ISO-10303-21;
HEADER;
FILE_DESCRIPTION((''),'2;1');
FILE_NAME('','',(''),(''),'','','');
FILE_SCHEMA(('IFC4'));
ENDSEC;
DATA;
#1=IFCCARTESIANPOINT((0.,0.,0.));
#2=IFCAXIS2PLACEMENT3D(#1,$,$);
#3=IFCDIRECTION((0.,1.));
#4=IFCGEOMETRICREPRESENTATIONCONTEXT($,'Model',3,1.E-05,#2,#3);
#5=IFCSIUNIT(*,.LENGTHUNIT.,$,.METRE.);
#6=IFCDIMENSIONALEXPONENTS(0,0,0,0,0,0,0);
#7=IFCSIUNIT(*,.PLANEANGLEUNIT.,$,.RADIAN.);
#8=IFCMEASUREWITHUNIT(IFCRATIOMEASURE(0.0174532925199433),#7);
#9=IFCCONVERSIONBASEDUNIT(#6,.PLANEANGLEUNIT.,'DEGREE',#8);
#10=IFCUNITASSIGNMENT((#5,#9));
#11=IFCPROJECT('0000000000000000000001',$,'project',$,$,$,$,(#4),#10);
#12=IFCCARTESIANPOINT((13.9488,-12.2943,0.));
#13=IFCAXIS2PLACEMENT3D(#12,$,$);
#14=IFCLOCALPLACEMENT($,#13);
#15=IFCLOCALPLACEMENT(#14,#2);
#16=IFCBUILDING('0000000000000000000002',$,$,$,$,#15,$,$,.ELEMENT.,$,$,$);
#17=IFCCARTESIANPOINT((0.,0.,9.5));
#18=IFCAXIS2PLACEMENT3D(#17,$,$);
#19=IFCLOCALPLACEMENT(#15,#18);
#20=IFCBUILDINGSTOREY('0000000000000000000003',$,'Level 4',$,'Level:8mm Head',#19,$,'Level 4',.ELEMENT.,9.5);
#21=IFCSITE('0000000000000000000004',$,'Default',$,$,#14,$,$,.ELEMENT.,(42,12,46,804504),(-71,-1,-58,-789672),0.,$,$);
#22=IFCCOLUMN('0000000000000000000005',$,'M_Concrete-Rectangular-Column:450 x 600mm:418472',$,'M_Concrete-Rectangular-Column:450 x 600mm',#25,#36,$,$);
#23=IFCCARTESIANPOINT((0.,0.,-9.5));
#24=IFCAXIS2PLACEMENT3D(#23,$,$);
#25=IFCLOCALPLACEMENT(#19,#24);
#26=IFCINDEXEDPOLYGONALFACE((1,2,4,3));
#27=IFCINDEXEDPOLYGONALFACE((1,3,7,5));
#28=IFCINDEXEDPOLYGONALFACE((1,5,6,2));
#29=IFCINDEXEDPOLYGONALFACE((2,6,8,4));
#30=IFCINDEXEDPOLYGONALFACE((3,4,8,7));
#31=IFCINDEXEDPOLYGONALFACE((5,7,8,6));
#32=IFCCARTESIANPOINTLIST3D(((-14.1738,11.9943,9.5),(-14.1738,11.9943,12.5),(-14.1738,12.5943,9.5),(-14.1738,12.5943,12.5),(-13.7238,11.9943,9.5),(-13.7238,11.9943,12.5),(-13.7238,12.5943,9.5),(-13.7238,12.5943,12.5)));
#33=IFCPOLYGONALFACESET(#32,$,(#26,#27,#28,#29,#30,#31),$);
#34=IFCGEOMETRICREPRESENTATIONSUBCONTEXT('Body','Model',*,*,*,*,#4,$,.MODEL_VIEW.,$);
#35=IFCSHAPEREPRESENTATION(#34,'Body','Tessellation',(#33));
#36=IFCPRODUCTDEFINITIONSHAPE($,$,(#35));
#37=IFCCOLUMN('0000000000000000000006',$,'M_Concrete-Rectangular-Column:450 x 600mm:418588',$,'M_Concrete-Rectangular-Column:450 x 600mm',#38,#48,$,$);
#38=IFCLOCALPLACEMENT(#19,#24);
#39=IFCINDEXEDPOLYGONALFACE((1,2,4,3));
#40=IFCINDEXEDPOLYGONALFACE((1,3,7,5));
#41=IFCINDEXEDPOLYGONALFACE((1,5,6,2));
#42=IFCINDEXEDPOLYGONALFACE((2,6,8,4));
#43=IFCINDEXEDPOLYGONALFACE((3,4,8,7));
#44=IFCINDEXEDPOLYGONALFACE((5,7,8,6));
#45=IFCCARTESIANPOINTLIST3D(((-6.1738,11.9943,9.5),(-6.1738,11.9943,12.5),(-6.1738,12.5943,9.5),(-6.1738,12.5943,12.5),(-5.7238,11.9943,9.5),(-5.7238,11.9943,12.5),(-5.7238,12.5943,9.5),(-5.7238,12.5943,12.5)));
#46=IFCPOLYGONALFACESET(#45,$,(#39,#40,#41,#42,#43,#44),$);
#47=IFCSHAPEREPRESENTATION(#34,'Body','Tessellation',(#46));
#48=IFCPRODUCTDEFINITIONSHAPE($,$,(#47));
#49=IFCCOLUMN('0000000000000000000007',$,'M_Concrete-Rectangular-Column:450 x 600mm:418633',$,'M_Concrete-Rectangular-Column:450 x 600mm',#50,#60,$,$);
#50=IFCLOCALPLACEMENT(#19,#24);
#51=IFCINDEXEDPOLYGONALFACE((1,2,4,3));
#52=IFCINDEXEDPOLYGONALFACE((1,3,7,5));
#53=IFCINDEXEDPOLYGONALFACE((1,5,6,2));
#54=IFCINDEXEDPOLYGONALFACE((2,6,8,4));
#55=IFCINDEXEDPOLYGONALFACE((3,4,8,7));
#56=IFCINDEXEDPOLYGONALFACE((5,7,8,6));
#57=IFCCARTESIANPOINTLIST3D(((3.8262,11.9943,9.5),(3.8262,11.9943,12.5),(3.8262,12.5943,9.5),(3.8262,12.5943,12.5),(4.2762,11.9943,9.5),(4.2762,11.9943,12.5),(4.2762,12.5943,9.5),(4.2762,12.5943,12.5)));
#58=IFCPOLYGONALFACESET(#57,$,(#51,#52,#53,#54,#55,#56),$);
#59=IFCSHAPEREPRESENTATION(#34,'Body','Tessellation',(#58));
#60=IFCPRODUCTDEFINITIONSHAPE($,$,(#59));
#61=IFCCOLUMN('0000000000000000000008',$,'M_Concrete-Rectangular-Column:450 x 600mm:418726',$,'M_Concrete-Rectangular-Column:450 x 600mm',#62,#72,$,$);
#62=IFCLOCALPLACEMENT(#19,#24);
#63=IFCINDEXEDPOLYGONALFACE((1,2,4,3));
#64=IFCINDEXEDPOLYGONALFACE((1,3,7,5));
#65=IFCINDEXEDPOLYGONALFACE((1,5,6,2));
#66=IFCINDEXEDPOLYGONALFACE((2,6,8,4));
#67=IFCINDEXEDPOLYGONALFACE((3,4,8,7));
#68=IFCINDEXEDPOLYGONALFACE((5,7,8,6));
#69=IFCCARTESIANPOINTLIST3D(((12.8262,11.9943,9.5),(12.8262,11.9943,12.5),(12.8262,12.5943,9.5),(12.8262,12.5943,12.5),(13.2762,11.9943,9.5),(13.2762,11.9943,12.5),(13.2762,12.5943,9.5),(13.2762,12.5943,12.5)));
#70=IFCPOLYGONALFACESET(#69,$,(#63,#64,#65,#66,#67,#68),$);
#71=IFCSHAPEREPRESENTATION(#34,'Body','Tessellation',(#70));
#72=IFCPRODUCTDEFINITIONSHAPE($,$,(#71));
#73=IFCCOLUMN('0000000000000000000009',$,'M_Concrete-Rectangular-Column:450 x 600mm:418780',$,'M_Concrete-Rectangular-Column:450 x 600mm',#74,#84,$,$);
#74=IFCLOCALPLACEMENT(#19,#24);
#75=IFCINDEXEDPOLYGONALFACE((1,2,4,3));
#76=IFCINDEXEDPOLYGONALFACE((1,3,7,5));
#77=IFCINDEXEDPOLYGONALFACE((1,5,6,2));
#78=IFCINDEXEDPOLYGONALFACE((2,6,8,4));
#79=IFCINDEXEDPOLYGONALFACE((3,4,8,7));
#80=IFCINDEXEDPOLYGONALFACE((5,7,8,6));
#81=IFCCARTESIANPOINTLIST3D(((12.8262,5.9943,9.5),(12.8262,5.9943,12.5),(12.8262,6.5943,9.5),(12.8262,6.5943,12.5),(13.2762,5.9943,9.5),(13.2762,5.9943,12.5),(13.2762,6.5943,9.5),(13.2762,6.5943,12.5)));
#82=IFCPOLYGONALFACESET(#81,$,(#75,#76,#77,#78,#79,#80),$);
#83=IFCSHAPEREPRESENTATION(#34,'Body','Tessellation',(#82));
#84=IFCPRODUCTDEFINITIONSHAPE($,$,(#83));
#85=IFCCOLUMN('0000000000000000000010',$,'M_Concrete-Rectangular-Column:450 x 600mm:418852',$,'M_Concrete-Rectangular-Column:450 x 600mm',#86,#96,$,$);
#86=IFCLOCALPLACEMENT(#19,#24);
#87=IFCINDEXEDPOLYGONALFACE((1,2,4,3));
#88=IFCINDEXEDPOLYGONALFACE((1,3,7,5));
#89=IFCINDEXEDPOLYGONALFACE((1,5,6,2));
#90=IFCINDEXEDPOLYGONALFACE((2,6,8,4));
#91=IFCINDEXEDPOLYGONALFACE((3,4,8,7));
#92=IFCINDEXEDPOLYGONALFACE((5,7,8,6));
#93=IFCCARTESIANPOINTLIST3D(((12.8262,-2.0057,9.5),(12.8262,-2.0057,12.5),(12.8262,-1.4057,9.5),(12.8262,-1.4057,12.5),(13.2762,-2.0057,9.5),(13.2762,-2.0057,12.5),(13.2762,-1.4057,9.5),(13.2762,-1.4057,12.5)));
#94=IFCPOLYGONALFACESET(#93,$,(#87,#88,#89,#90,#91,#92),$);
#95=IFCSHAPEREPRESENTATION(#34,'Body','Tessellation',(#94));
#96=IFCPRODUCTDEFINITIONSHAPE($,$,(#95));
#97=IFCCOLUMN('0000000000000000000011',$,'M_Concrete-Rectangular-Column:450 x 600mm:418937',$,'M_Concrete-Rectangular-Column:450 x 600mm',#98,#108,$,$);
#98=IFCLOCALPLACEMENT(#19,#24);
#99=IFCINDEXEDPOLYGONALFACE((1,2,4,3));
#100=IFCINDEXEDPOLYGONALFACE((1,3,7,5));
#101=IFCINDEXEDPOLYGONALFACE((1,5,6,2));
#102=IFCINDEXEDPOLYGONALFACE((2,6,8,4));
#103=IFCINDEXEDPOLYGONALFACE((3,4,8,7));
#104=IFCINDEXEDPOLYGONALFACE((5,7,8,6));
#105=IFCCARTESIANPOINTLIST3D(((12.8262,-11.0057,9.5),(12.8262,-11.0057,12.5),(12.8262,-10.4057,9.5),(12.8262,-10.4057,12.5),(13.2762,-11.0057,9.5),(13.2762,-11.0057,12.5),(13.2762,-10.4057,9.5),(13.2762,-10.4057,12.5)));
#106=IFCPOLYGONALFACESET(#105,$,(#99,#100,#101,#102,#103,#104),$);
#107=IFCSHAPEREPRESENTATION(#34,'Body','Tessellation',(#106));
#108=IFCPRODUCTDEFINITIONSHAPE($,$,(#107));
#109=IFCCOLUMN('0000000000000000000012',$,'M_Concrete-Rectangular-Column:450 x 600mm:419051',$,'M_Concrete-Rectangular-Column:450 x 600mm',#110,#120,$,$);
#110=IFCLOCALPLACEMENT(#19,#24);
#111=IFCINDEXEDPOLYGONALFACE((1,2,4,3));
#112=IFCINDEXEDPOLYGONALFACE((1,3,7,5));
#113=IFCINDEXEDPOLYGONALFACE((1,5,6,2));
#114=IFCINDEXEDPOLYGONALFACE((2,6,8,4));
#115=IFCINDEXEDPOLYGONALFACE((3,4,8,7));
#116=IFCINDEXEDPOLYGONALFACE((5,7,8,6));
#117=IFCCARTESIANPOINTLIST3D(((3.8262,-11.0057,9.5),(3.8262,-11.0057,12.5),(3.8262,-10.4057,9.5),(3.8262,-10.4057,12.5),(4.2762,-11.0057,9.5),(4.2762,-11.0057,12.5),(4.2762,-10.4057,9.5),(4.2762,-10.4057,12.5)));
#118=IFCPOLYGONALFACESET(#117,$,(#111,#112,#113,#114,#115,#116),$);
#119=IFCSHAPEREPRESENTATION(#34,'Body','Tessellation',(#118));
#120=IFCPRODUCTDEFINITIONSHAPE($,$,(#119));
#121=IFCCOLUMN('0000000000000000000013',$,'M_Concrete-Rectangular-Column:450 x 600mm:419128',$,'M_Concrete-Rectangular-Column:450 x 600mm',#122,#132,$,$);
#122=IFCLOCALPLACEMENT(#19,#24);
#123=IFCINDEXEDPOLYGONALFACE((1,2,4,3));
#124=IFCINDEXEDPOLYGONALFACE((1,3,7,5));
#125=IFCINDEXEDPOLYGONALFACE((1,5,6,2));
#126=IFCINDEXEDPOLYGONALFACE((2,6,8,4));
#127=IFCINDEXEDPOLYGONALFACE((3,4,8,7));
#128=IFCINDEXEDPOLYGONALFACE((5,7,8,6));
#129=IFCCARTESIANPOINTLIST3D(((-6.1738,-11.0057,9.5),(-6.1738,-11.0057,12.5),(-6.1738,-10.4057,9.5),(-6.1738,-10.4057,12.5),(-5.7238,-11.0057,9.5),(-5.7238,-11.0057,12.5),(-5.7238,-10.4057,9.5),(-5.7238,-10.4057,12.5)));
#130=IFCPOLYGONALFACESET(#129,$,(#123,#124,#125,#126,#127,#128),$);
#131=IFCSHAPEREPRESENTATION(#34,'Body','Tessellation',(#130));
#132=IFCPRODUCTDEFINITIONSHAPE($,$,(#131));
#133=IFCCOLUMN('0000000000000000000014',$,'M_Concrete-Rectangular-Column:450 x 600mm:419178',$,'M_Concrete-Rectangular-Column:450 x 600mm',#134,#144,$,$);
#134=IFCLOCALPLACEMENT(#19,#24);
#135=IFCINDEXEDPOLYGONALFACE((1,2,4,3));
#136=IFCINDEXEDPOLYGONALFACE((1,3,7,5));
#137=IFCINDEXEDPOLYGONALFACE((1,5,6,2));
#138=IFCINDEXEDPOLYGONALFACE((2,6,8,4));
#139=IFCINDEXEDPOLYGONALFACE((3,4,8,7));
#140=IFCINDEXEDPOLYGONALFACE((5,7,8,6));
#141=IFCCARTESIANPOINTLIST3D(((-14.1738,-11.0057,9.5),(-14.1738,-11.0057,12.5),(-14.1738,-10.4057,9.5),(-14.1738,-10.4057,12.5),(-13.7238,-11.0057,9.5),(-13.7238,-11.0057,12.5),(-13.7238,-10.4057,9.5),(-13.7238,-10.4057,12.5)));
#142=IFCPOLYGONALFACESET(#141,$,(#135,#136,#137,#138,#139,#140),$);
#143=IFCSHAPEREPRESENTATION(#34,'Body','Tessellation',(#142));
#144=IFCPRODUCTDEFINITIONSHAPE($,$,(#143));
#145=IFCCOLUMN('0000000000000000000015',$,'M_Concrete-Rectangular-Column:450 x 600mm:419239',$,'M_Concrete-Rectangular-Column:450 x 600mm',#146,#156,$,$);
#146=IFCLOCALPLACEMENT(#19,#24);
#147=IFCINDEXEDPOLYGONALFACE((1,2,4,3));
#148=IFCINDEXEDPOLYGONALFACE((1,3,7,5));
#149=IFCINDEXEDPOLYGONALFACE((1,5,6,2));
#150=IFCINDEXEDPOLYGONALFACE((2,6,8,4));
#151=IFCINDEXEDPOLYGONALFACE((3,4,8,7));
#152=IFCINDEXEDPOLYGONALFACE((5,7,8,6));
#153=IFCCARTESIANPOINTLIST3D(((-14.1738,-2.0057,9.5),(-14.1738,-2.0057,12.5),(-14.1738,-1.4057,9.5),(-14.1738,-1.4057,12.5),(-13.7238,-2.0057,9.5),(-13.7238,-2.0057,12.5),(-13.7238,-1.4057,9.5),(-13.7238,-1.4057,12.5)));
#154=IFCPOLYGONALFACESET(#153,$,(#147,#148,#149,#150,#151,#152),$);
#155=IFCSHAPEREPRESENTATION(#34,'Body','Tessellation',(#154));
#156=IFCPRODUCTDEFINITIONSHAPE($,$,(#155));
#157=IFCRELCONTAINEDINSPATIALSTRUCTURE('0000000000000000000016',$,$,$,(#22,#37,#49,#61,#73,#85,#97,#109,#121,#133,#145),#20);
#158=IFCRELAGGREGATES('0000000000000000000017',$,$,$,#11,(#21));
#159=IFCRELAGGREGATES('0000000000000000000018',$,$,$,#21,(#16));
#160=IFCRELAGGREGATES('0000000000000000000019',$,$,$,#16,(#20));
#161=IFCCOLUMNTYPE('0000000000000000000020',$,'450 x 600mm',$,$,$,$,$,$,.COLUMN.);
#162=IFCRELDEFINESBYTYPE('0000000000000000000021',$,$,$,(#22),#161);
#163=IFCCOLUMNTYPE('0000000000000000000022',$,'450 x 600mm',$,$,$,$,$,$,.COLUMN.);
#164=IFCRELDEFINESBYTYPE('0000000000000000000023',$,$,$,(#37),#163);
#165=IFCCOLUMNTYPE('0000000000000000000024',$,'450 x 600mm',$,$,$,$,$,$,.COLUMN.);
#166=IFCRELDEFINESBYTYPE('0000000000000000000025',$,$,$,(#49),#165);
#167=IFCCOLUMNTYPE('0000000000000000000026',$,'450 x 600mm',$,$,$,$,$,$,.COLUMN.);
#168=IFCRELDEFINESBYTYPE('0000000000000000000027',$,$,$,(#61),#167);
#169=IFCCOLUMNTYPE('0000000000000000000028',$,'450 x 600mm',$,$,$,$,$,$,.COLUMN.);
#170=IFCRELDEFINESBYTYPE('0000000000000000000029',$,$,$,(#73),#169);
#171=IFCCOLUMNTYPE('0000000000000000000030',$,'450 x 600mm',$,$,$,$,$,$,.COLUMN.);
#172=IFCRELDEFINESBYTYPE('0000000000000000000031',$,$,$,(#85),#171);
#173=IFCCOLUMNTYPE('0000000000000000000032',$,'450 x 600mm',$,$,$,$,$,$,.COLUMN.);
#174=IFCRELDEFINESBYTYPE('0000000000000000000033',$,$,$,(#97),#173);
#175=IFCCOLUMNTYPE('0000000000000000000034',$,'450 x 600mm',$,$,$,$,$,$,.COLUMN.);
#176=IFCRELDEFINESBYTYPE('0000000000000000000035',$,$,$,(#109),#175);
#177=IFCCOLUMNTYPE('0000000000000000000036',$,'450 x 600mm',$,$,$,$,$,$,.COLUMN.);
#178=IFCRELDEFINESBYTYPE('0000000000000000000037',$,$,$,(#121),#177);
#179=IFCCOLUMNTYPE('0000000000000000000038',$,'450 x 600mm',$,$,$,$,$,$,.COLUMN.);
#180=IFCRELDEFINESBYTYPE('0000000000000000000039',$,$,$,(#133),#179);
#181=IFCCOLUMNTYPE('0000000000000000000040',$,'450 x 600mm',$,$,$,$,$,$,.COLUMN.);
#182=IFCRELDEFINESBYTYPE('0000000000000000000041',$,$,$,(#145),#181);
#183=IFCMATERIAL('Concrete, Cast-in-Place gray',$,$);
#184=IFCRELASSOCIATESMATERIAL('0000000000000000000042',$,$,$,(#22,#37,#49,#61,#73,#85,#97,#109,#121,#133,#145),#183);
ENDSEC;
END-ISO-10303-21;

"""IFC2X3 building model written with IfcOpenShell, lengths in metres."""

from ifc_helpers import new_model, entity, si_unit, converted_unit, direction, frame, frame_2d, origin, origin_2d_with_axis, place, context, subcontext, project, spatial, rectangle, extrude, source, transform, mapped, material, type_object, type_shapes, element, save


model = new_model("IFC2X3")

# Units and contexts
model_context = context("Model", 3, precision=1e-05, world=origin(), true_north=direction((0.0, 1.0)))
body_context = subcontext(model_context, "Body", "Model", "MODEL_VIEW")
ifc_project = project(units=[si_unit("LENGTHUNIT", "METRE"), converted_unit("PLANEANGLEUNIT", "DEGREE", entity("IfcRatioMeasure", 0.0174532925199433), si_unit("PLANEANGLEUNIT", "RADIAN"), dimensions=[0, 0, 0, 0, 0, 0, 0])], contexts=[model_context])

# Site, building, storey
site_placement = place(None, frame((13.9488, -12.2943, 0.0)))
site = spatial("IfcSite", under=ifc_project, at=site_placement, Name="Default", CompositionType="ELEMENT", RefLatitude=(42, 12, 46, 804504), RefLongitude=(-71, -1, -58, -789672), RefElevation=0.0)
building_placement = place(site_placement, origin())
building = spatial("IfcBuilding", under=site, at=building_placement, CompositionType="ELEMENT")
storey_placement = place(building_placement, frame((0.0, 0.0, 9.5)))
storey = spatial("IfcBuildingStorey", under=building, at=storey_placement, Name="Level 4", ObjectType="Level:8mm Head", LongName="Level 4", CompositionType="ELEMENT", Elevation=9.5)

# Columns
ifc_material = material(Name="Concrete, Cast-in-Place gray")
column_type_1 = type_object("IfcColumnType", Name="450 x 600mm", PredefinedType="COLUMN")
shared_shape_1 = source(origin(), body_context, "Body", "SweptSolid", [
    extrude(rectangle(XDim=0.6, YDim=0.45, at=frame_2d((0.0, 0.0), x_axis=(1.0, 0.0))), frame((-13.9488, 12.2943, 9.5), z_axis=(0.0, 0.0, 1.0), x_axis=(0.0, -1.0, 0.0)), (0.0, 0.0, 1.0), 3.0),
])
type_shapes(column_type_1, [shared_shape_1])
column_1_placement = place(storey_placement, frame((0.0, 0.0, -9.5)))
element("IfcColumn", 1, at=column_1_placement, inside=storey, type_object=column_type_1, material=ifc_material, Name="M_Concrete-Rectangular-Column:450 x 600mm:418472", ObjectType="M_Concrete-Rectangular-Column:450 x 600mm", context=body_context, shape_type="MappedRepresentation", body=[
    mapped(shared_shape_1, transform((0.0, 0.0, 0.0), scale=1.0)),
])
column_type_2 = type_object("IfcColumnType", Name="450 x 600mm", PredefinedType="COLUMN")
shared_shape_2 = source(origin(), body_context, "Body", "SweptSolid", [
    extrude(rectangle(XDim=0.6, YDim=0.45, at=frame_2d((0.0, 0.0), x_axis=(1.0, 0.0))), frame((-5.9488, 12.2943, 9.5), z_axis=(0.0, 0.0, 1.0), x_axis=(0.0, -1.0, 0.0)), (0.0, 0.0, 1.0), 3.0),
])
type_shapes(column_type_2, [shared_shape_2])
column_2_placement = place(storey_placement, frame((0.0, 0.0, -9.5)))
element("IfcColumn", 2, at=column_2_placement, inside=storey, type_object=column_type_2, material=ifc_material, Name="M_Concrete-Rectangular-Column:450 x 600mm:418588", ObjectType="M_Concrete-Rectangular-Column:450 x 600mm", context=body_context, shape_type="MappedRepresentation", body=[
    mapped(shared_shape_2, transform((0.0, 0.0, 0.0), scale=1.0)),
])
column_type_3 = type_object("IfcColumnType", Name="450 x 600mm", PredefinedType="COLUMN")
shared_shape_3 = source(origin(), body_context, "Body", "SweptSolid", [
    extrude(rectangle(XDim=0.6, YDim=0.45, at=frame_2d((0.0, 0.0), x_axis=(1.0, 0.0))), frame((4.0512, 12.2943, 9.5), z_axis=(0.0, 0.0, 1.0), x_axis=(0.0, -1.0, 0.0)), (0.0, 0.0, 1.0), 3.0),
])
type_shapes(column_type_3, [shared_shape_3])
column_3_placement = place(storey_placement, frame((0.0, 0.0, -9.5)))
element("IfcColumn", 3, at=column_3_placement, inside=storey, type_object=column_type_3, material=ifc_material, Name="M_Concrete-Rectangular-Column:450 x 600mm:418633", ObjectType="M_Concrete-Rectangular-Column:450 x 600mm", context=body_context, shape_type="MappedRepresentation", body=[
    mapped(shared_shape_3, transform((0.0, 0.0, 0.0), scale=1.0)),
])
column_type_4 = type_object("IfcColumnType", Name="450 x 600mm", PredefinedType="COLUMN")
shared_shape_4 = source(origin(), body_context, "Body", "SweptSolid", [
    extrude(rectangle(XDim=0.6, YDim=0.45, at=frame_2d((0.0, 0.0), x_axis=(1.0, 0.0))), frame((13.0512, 12.2943, 9.5), z_axis=(0.0, 0.0, 1.0), x_axis=(0.0, -1.0, 0.0)), (0.0, 0.0, 1.0), 3.0),
])
type_shapes(column_type_4, [shared_shape_4])
column_4_placement = place(storey_placement, frame((0.0, 0.0, -9.5)))
element("IfcColumn", 4, at=column_4_placement, inside=storey, type_object=column_type_4, material=ifc_material, Name="M_Concrete-Rectangular-Column:450 x 600mm:418726", ObjectType="M_Concrete-Rectangular-Column:450 x 600mm", context=body_context, shape_type="MappedRepresentation", body=[
    mapped(shared_shape_4, transform((0.0, 0.0, 0.0), scale=1.0)),
])
column_type_5 = type_object("IfcColumnType", Name="450 x 600mm", PredefinedType="COLUMN")
shared_shape_5 = source(origin(), body_context, "Body", "SweptSolid", [
    extrude(rectangle(XDim=0.6, YDim=0.45, at=origin_2d_with_axis()), frame((13.0512, 6.2943, 9.5), z_axis=(0.0, 0.0, 1.0), x_axis=(0.0, -1.0, 0.0)), (0.0, 0.0, 1.0), 3.0),
])
type_shapes(column_type_5, [shared_shape_5])
column_5_placement = place(storey_placement, frame((0.0, 0.0, -9.5)))
element("IfcColumn", 5, at=column_5_placement, inside=storey, type_object=column_type_5, material=ifc_material, Name="M_Concrete-Rectangular-Column:450 x 600mm:418780", ObjectType="M_Concrete-Rectangular-Column:450 x 600mm", context=body_context, shape_type="MappedRepresentation", body=[
    mapped(shared_shape_5, transform((0.0, 0.0, 0.0), scale=1.0)),
])
column_type_6 = type_object("IfcColumnType", Name="450 x 600mm", PredefinedType="COLUMN")
shared_shape_6 = source(origin(), body_context, "Body", "SweptSolid", [
    extrude(rectangle(XDim=0.6, YDim=0.45, at=origin_2d_with_axis()), frame((13.0512, -1.7057, 9.5), z_axis=(0.0, 0.0, 1.0), x_axis=(0.0, -1.0, 0.0)), (0.0, 0.0, 1.0), 3.0),
])
type_shapes(column_type_6, [shared_shape_6])
column_6_placement = place(storey_placement, frame((0.0, 0.0, -9.5)))
element("IfcColumn", 6, at=column_6_placement, inside=storey, type_object=column_type_6, material=ifc_material, Name="M_Concrete-Rectangular-Column:450 x 600mm:418852", ObjectType="M_Concrete-Rectangular-Column:450 x 600mm", context=body_context, shape_type="MappedRepresentation", body=[
    mapped(shared_shape_6, transform((0.0, 0.0, 0.0), scale=1.0)),
])
column_type_7 = type_object("IfcColumnType", Name="450 x 600mm", PredefinedType="COLUMN")
shared_shape_7 = source(origin(), body_context, "Body", "SweptSolid", [
    extrude(rectangle(XDim=0.6, YDim=0.45, at=frame_2d((0.0, 0.0), x_axis=(1.0, 0.0))), frame((13.0512, -10.7057, 9.5), z_axis=(0.0, 0.0, 1.0), x_axis=(0.0, -1.0, 0.0)), (0.0, 0.0, 1.0), 3.0),
])
type_shapes(column_type_7, [shared_shape_7])
column_7_placement = place(storey_placement, frame((0.0, 0.0, -9.5)))
element("IfcColumn", 7, at=column_7_placement, inside=storey, type_object=column_type_7, material=ifc_material, Name="M_Concrete-Rectangular-Column:450 x 600mm:418937", ObjectType="M_Concrete-Rectangular-Column:450 x 600mm", context=body_context, shape_type="MappedRepresentation", body=[
    mapped(shared_shape_7, transform((0.0, 0.0, 0.0), scale=1.0)),
])
column_type_8 = type_object("IfcColumnType", Name="450 x 600mm", PredefinedType="COLUMN")
shared_shape_8 = source(origin(), body_context, "Body", "SweptSolid", [
    extrude(rectangle(XDim=0.6, YDim=0.45, at=frame_2d((0.0, 0.0), x_axis=(1.0, 0.0))), frame((4.0512, -10.7057, 9.5), z_axis=(0.0, 0.0, 1.0), x_axis=(0.0, -1.0, 0.0)), (0.0, 0.0, 1.0), 3.0),
])
type_shapes(column_type_8, [shared_shape_8])
column_8_placement = place(storey_placement, frame((0.0, 0.0, -9.5)))
element("IfcColumn", 8, at=column_8_placement, inside=storey, type_object=column_type_8, material=ifc_material, Name="M_Concrete-Rectangular-Column:450 x 600mm:419051", ObjectType="M_Concrete-Rectangular-Column:450 x 600mm", context=body_context, shape_type="MappedRepresentation", body=[
    mapped(shared_shape_8, transform((0.0, 0.0, 0.0), scale=1.0)),
])
column_type_9 = type_object("IfcColumnType", Name="450 x 600mm", PredefinedType="COLUMN")
shared_shape_9 = source(origin(), body_context, "Body", "SweptSolid", [
    extrude(rectangle(XDim=0.6, YDim=0.45, at=frame_2d((0.0, 0.0), x_axis=(1.0, 0.0))), frame((-5.9488, -10.7057, 9.5), z_axis=(0.0, 0.0, 1.0), x_axis=(0.0, -1.0, 0.0)), (0.0, 0.0, 1.0), 3.0),
])
type_shapes(column_type_9, [shared_shape_9])
column_9_placement = place(storey_placement, frame((0.0, 0.0, -9.5)))
element("IfcColumn", 9, at=column_9_placement, inside=storey, type_object=column_type_9, material=ifc_material, Name="M_Concrete-Rectangular-Column:450 x 600mm:419128", ObjectType="M_Concrete-Rectangular-Column:450 x 600mm", context=body_context, shape_type="MappedRepresentation", body=[
    mapped(shared_shape_9, transform((0.0, 0.0, 0.0), scale=1.0)),
])
column_type_10 = type_object("IfcColumnType", Name="450 x 600mm", PredefinedType="COLUMN")
shared_shape_10 = source(origin(), body_context, "Body", "SweptSolid", [
    extrude(rectangle(XDim=0.6, YDim=0.45, at=frame_2d((0.0, 0.0), x_axis=(1.0, 0.0))), frame((-13.9488, -10.7057, 9.5), z_axis=(0.0, 0.0, 1.0), x_axis=(0.0, -1.0, 0.0)), (0.0, 0.0, 1.0), 3.0),
])
type_shapes(column_type_10, [shared_shape_10])
column_10_placement = place(storey_placement, frame((0.0, 0.0, -9.5)))
element("IfcColumn", 10, at=column_10_placement, inside=storey, type_object=column_type_10, material=ifc_material, Name="M_Concrete-Rectangular-Column:450 x 600mm:419178", ObjectType="M_Concrete-Rectangular-Column:450 x 600mm", context=body_context, shape_type="MappedRepresentation", body=[
    mapped(shared_shape_10, transform((0.0, 0.0, 0.0), scale=1.0)),
])
column_type_11 = type_object("IfcColumnType", Name="450 x 600mm", PredefinedType="COLUMN")
shared_shape_11 = source(origin(), body_context, "Body", "SweptSolid", [
    extrude(rectangle(XDim=0.6, YDim=0.45, at=origin_2d_with_axis()), frame((-13.9488, -1.7057, 9.5), z_axis=(0.0, 0.0, 1.0), x_axis=(0.0, -1.0, 0.0)), (0.0, 0.0, 1.0), 3.0),
])
type_shapes(column_type_11, [shared_shape_11])
column_11_placement = place(storey_placement, frame((0.0, 0.0, -9.5)))
element("IfcColumn", 11, at=column_11_placement, inside=storey, type_object=column_type_11, material=ifc_material, Name="M_Concrete-Rectangular-Column:450 x 600mm:419239", ObjectType="M_Concrete-Rectangular-Column:450 x 600mm", context=body_context, shape_type="MappedRepresentation", body=[
    mapped(shared_shape_11, transform((0.0, 0.0, 0.0), scale=1.0)),
])

save(model, "model.ifc")
